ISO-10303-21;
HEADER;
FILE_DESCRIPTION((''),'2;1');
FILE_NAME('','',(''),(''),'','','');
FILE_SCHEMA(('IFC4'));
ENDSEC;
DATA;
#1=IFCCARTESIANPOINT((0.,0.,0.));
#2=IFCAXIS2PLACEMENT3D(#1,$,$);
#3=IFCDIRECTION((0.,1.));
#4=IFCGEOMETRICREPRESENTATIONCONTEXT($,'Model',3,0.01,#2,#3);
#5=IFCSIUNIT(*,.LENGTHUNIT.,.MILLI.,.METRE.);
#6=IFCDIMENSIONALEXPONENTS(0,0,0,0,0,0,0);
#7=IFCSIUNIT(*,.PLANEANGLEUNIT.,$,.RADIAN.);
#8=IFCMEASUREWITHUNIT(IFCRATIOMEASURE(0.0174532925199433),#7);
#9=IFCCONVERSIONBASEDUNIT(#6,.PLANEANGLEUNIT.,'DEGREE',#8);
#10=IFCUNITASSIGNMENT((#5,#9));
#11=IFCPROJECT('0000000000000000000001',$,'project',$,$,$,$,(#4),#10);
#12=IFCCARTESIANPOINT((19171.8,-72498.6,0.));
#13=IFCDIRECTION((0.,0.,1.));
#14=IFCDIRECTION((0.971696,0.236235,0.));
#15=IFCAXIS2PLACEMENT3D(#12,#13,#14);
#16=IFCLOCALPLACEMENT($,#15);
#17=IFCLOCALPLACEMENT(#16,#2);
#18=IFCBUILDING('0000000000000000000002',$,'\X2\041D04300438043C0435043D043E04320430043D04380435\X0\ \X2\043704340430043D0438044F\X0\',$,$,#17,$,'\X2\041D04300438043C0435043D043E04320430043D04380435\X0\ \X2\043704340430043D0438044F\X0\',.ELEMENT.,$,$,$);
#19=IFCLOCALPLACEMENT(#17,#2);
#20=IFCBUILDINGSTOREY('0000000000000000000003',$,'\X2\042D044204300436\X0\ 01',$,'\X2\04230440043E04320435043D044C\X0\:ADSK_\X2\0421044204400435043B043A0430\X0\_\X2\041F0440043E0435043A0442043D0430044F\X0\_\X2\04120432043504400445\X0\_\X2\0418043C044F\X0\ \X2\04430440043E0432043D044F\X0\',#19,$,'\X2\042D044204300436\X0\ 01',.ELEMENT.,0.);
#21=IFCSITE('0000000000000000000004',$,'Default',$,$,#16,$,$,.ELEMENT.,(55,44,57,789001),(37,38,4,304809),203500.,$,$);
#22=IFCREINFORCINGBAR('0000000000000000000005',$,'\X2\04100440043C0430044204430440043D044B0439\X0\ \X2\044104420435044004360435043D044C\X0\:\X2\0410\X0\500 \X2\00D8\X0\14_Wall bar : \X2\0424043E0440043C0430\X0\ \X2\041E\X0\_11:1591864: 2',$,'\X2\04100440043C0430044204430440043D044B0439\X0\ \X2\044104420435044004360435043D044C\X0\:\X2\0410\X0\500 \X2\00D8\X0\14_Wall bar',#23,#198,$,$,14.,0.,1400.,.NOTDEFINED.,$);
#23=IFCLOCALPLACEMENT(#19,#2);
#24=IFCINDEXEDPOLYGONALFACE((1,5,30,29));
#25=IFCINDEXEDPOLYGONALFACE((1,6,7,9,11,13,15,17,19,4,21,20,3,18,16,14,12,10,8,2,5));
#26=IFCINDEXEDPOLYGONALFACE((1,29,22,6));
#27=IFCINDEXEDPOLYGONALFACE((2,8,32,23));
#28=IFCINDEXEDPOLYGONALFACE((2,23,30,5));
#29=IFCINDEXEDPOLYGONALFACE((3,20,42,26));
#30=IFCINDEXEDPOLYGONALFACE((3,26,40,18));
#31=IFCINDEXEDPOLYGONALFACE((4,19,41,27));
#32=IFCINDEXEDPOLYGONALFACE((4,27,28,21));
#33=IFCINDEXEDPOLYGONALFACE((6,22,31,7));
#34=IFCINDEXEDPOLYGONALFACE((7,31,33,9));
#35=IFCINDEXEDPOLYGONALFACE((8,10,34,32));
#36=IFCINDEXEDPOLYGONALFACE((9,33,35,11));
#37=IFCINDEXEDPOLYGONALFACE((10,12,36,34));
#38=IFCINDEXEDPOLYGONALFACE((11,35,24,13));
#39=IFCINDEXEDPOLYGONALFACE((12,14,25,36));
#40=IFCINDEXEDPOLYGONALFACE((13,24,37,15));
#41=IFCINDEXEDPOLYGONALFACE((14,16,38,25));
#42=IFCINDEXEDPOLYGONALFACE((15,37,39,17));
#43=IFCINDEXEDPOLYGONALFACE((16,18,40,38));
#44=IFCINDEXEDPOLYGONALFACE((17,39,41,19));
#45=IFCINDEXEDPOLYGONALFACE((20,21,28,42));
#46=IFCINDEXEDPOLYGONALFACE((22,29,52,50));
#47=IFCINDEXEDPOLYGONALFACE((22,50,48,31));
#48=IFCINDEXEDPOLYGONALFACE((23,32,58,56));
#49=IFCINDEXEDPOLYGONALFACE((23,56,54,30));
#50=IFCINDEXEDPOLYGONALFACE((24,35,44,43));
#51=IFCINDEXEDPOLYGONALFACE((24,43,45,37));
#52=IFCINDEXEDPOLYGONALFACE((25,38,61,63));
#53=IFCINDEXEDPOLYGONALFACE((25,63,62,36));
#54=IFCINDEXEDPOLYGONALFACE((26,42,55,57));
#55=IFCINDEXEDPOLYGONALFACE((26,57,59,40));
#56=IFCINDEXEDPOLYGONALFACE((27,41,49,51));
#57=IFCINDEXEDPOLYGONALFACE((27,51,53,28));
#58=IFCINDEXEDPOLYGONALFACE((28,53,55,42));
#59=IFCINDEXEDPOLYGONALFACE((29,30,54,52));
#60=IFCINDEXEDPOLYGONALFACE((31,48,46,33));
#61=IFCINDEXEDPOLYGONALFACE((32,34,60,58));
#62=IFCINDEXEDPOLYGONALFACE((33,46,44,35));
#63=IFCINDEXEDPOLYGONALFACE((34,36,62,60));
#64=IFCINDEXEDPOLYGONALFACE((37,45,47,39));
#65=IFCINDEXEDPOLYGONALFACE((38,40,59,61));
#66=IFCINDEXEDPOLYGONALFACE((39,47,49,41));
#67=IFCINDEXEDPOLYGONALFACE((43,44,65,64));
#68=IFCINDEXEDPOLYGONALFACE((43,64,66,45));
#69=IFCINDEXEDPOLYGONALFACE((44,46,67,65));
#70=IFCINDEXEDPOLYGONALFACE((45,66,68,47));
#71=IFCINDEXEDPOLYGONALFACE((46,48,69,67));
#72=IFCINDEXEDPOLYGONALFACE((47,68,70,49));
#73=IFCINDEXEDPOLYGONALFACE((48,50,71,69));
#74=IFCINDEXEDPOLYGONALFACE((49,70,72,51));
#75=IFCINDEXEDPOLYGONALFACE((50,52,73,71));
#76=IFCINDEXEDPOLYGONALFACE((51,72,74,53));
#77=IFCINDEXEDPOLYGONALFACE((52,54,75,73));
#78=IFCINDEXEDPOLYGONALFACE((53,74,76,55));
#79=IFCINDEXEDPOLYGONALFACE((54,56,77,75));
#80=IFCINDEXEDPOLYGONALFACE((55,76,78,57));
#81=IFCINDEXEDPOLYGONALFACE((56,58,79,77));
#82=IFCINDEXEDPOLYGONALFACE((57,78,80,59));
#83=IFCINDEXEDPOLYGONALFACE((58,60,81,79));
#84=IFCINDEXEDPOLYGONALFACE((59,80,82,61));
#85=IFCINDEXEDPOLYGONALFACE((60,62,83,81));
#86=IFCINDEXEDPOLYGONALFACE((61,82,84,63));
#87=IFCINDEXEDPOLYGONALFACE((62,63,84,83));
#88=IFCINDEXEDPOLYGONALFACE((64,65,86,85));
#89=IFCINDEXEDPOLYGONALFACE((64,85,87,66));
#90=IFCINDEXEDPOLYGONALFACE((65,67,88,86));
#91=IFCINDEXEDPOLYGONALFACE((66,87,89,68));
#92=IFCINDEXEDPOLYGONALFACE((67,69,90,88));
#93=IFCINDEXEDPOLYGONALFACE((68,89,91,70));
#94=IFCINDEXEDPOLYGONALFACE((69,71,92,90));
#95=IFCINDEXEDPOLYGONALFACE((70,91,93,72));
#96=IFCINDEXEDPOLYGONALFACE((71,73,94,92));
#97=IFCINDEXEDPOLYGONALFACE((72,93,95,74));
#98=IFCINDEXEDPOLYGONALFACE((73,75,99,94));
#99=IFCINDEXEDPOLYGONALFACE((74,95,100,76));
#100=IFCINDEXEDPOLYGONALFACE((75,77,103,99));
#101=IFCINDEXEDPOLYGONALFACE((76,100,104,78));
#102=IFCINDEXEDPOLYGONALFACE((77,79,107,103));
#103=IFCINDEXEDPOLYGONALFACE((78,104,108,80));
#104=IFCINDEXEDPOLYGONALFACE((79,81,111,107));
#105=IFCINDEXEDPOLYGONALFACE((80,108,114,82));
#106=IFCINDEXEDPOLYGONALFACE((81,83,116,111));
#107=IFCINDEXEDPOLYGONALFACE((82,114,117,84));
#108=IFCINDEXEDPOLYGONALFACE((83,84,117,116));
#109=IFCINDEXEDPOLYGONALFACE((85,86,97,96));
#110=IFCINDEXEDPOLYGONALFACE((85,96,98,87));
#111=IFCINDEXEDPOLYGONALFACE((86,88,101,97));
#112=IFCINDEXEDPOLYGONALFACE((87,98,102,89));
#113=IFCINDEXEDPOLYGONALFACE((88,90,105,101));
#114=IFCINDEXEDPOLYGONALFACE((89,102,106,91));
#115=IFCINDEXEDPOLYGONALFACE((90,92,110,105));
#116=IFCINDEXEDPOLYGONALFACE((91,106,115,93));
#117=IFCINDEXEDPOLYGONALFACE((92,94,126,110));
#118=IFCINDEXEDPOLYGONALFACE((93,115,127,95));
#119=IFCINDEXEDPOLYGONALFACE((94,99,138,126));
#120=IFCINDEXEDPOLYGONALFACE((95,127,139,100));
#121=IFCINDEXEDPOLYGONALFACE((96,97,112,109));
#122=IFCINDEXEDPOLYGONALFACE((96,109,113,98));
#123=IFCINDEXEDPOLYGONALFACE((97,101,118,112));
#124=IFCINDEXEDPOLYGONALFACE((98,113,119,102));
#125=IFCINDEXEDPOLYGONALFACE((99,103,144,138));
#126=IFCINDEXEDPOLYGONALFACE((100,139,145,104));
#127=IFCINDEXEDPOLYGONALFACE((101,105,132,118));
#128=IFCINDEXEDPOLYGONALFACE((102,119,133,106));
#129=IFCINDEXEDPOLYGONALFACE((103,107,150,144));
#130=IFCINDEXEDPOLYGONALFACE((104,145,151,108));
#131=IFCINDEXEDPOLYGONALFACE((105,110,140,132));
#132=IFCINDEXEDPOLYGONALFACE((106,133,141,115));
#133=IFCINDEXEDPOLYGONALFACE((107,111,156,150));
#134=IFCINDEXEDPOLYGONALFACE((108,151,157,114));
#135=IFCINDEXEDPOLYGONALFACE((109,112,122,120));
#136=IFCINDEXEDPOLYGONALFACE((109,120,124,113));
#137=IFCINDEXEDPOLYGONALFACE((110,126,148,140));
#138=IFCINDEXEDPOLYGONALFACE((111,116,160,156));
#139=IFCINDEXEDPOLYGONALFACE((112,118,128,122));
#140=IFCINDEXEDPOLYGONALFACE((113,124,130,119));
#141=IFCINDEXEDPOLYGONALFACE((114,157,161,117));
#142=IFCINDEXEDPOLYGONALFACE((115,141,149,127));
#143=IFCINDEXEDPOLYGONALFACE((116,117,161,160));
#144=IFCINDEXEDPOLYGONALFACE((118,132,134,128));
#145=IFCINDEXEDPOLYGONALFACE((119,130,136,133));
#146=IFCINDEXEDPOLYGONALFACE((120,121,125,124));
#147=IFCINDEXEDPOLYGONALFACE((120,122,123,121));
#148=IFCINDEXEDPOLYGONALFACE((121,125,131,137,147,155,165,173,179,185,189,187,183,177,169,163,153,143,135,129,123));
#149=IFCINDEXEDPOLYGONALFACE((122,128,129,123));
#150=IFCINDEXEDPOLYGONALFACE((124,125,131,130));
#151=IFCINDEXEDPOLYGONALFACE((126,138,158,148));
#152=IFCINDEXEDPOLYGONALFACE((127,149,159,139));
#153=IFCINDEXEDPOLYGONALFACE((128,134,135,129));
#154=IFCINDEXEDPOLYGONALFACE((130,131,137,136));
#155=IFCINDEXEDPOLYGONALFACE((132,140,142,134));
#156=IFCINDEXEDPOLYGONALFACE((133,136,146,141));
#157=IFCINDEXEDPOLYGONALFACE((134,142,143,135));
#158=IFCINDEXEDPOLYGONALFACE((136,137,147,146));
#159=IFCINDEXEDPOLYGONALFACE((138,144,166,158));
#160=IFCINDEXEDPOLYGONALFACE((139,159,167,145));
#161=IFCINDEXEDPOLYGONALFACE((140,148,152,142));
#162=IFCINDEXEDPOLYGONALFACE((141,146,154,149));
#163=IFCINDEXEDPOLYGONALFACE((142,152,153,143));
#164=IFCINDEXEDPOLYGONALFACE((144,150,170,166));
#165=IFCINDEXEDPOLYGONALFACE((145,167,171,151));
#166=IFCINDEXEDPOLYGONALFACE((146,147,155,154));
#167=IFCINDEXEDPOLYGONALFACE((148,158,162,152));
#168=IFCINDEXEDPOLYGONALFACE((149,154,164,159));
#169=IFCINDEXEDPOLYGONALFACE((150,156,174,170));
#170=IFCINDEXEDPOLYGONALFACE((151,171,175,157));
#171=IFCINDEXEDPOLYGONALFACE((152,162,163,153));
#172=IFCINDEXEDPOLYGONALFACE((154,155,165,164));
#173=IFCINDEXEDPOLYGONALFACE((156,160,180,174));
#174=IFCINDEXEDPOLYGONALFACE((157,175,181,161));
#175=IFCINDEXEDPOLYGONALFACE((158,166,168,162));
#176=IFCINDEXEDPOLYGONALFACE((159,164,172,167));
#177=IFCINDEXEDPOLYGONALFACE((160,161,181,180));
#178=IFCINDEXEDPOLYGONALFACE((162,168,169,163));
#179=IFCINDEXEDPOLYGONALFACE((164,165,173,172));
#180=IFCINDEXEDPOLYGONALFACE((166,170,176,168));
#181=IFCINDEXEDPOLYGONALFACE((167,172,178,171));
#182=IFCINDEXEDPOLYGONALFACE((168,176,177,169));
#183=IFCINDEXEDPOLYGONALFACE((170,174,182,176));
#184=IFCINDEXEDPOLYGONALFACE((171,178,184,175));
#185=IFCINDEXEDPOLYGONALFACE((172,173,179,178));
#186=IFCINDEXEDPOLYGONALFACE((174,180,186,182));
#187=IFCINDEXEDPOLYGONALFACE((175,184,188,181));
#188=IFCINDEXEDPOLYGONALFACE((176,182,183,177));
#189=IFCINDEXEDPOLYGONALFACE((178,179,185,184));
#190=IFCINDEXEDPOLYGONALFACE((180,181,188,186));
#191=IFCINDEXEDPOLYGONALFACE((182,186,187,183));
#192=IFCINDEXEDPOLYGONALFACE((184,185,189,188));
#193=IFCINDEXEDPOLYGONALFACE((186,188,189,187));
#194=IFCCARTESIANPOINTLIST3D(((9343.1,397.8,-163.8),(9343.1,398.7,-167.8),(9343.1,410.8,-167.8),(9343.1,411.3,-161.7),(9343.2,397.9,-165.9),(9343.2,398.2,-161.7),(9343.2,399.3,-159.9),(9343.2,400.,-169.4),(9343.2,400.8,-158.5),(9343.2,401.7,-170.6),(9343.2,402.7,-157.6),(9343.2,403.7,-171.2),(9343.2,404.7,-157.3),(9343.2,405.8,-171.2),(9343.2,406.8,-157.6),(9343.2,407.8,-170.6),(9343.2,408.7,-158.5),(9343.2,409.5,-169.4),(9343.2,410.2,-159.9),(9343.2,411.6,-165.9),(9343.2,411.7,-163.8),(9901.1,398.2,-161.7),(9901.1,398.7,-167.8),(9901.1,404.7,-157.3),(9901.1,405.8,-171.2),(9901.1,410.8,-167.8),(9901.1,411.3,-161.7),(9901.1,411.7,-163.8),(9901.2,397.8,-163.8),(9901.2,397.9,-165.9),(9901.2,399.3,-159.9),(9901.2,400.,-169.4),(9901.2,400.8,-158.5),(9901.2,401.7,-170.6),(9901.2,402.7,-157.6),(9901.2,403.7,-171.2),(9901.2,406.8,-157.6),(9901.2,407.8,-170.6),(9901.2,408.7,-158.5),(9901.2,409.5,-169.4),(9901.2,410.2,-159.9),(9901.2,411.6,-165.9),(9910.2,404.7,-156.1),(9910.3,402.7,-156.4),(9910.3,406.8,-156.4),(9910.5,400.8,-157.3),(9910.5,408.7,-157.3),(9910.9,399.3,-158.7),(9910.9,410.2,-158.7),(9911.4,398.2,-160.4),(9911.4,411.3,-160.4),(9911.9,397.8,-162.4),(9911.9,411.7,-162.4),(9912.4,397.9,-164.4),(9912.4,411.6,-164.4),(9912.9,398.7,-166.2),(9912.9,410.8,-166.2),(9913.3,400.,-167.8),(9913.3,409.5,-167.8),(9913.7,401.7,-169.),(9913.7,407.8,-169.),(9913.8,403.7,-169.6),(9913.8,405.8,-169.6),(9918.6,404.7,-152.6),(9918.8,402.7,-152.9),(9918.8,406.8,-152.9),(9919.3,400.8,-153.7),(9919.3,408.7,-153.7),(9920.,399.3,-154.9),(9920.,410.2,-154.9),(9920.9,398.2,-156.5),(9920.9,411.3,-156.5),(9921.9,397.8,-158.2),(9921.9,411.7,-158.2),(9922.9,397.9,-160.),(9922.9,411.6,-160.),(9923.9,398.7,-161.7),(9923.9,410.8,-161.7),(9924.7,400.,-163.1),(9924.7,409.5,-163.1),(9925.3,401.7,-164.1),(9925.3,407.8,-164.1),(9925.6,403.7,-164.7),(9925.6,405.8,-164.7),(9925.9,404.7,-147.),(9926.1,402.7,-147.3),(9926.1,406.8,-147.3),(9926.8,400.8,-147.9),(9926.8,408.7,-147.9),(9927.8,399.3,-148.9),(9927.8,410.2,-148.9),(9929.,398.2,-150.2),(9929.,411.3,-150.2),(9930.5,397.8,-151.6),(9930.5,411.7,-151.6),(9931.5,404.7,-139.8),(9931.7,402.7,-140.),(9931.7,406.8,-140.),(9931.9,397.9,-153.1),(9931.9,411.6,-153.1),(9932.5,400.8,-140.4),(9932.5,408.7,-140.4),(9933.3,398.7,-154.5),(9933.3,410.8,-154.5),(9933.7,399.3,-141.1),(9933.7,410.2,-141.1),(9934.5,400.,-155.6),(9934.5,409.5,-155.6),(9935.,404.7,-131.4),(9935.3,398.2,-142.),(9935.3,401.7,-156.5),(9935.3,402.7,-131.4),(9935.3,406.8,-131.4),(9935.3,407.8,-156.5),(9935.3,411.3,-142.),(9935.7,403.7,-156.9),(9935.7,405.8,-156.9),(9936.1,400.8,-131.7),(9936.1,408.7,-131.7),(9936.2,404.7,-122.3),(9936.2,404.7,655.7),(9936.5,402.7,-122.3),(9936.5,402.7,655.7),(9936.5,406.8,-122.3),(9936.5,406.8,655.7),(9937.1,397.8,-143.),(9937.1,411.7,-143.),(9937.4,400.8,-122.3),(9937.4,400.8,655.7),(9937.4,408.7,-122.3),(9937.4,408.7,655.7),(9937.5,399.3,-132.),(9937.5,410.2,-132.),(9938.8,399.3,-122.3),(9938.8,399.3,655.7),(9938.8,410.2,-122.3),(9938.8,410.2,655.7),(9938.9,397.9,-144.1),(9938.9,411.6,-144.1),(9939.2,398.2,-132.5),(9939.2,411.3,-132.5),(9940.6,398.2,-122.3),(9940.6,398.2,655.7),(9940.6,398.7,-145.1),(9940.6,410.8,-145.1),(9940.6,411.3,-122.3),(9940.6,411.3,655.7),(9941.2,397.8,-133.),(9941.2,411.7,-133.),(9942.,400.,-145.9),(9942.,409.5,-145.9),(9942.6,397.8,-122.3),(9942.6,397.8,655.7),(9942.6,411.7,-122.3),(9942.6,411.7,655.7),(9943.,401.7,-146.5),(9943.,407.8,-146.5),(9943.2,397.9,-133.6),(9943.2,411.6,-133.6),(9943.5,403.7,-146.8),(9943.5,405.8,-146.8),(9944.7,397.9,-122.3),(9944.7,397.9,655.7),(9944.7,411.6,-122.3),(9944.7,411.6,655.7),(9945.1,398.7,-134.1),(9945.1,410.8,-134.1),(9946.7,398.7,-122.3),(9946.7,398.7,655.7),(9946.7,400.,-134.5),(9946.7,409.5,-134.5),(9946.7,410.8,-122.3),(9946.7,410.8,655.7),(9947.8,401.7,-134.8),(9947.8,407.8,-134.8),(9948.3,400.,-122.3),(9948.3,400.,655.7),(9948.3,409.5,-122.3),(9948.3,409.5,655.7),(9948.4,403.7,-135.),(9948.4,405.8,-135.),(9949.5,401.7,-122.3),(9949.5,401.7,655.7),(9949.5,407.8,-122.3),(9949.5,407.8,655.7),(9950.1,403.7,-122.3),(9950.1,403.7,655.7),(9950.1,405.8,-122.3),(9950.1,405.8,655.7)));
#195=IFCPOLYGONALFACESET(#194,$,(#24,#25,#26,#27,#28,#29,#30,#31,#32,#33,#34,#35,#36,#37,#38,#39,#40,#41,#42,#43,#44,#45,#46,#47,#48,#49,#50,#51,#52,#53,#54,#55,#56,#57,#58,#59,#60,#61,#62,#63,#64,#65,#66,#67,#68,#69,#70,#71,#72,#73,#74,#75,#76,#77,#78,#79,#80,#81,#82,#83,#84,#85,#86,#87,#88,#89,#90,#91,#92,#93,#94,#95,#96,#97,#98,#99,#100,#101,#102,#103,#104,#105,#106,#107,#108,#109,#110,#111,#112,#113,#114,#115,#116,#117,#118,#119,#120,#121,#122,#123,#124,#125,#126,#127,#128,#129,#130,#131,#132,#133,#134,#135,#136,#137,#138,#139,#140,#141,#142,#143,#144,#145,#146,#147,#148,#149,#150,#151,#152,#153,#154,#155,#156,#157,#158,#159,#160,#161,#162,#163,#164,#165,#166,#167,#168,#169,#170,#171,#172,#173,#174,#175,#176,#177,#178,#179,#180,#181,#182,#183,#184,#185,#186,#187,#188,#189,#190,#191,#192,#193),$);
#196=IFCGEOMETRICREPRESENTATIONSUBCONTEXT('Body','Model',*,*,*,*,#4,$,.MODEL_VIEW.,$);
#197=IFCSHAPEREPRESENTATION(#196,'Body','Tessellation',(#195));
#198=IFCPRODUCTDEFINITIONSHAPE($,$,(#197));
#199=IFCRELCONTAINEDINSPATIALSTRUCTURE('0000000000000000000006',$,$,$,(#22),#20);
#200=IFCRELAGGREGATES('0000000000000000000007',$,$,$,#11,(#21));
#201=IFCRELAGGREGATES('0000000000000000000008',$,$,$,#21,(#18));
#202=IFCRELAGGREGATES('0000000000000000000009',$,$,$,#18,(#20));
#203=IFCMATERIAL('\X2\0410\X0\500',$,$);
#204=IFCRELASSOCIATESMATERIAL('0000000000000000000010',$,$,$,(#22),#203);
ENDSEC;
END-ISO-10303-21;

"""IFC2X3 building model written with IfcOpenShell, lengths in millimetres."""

from ifc_helpers import new_model, entity, si_unit, converted_unit, direction, frame, origin, place, context, subcontext, project, spatial, material, element, save


model = new_model("IFC2X3")

# Units and contexts
model_context = context("Model", 3, precision=0.01, world=origin(), true_north=direction((0.0, 1.0)))
body_context = subcontext(model_context, "Body", "Model", "MODEL_VIEW")
ifc_project = project(units=[si_unit("LENGTHUNIT", "METRE", prefix="MILLI"), converted_unit("PLANEANGLEUNIT", "DEGREE", entity("IfcRatioMeasure", 0.0174532925199433), si_unit("PLANEANGLEUNIT", "RADIAN"), dimensions=[0, 0, 0, 0, 0, 0, 0])], contexts=[model_context])

# Site, building, storey
site_placement = place(None, frame((19171.8, -72498.6, 0.0), z_axis=(0.0, 0.0, 1.0), x_axis=(0.971696, 0.236235, 0.0)))
site = spatial("IfcSite", under=ifc_project, at=site_placement, Name="Default", CompositionType="ELEMENT", RefLatitude=(55, 44, 57, 789001), RefLongitude=(37, 38, 4, 304809), RefElevation=203500.0)
building_placement = place(site_placement, origin())
building = spatial("IfcBuilding", under=site, at=building_placement, Name="Наименование здания", LongName="Наименование здания", CompositionType="ELEMENT")
storey_placement = place(building_placement, origin())
storey = spatial("IfcBuildingStorey", under=building, at=storey_placement, Name="Этаж 01", ObjectType="Уровень:ADSK_Стрелка_Проектная_Вверх_Имя уровня", LongName="Этаж 01", CompositionType="ELEMENT", Elevation=0.0)

# Reinforcing bar
ifc_material = material(Name="А500")
placement = place(storey_placement, origin())
element("IfcReinforcingBar", 1, at=placement, inside=storey, material=ifc_material, Name="Арматурный стержень:А500 Ø14_Wall bar : Форма О_11:1591864: 2", ObjectType="Арматурный стержень:А500 Ø14_Wall bar", BarLength=1400.0, BarRole="NOTDEFINED", CrossSectionArea=0.0, NominalDiameter=14.0, context=body_context, shape_type="AdvancedSweptSolid", body=[
    entity("IfcSweptDiskSolid", entity("IfcCompositeCurve", [entity("IfcCompositeCurveSegment", "CONTINUOUS", True, entity("IfcPolyline", [entity("IfcCartesianPoint", [9943.1, 404.7, 655.7]), entity("IfcCartesianPoint", [9943.1, 404.7, -122.3])])), entity("IfcCompositeCurveSegment", "CONTINUOUS", True, entity("IfcTrimmedCurve", entity("IfcCircle", entity("IfcAxis2Placement3D", entity("IfcCartesianPoint", [9901.1, 404.7, -122.3]), entity("IfcDirection", [0.0, 1.0, 0.0]), entity("IfcDirection", [0.0, 0.0, -1.0])), 42.0), [entity("IfcParameterValue", 270.0)], [entity("IfcParameterValue", 360.0)], True, "PARAMETER")), entity("IfcCompositeCurveSegment", "CONTINUOUS", True, entity("IfcPolyline", [entity("IfcCartesianPoint", [9901.1, 404.7, -164.3]), entity("IfcCartesianPoint", [9343.1, 404.7, -164.3])]))], False), 7.0, None, 0.0, 92.0),
])

save(model, "model.ifc")
